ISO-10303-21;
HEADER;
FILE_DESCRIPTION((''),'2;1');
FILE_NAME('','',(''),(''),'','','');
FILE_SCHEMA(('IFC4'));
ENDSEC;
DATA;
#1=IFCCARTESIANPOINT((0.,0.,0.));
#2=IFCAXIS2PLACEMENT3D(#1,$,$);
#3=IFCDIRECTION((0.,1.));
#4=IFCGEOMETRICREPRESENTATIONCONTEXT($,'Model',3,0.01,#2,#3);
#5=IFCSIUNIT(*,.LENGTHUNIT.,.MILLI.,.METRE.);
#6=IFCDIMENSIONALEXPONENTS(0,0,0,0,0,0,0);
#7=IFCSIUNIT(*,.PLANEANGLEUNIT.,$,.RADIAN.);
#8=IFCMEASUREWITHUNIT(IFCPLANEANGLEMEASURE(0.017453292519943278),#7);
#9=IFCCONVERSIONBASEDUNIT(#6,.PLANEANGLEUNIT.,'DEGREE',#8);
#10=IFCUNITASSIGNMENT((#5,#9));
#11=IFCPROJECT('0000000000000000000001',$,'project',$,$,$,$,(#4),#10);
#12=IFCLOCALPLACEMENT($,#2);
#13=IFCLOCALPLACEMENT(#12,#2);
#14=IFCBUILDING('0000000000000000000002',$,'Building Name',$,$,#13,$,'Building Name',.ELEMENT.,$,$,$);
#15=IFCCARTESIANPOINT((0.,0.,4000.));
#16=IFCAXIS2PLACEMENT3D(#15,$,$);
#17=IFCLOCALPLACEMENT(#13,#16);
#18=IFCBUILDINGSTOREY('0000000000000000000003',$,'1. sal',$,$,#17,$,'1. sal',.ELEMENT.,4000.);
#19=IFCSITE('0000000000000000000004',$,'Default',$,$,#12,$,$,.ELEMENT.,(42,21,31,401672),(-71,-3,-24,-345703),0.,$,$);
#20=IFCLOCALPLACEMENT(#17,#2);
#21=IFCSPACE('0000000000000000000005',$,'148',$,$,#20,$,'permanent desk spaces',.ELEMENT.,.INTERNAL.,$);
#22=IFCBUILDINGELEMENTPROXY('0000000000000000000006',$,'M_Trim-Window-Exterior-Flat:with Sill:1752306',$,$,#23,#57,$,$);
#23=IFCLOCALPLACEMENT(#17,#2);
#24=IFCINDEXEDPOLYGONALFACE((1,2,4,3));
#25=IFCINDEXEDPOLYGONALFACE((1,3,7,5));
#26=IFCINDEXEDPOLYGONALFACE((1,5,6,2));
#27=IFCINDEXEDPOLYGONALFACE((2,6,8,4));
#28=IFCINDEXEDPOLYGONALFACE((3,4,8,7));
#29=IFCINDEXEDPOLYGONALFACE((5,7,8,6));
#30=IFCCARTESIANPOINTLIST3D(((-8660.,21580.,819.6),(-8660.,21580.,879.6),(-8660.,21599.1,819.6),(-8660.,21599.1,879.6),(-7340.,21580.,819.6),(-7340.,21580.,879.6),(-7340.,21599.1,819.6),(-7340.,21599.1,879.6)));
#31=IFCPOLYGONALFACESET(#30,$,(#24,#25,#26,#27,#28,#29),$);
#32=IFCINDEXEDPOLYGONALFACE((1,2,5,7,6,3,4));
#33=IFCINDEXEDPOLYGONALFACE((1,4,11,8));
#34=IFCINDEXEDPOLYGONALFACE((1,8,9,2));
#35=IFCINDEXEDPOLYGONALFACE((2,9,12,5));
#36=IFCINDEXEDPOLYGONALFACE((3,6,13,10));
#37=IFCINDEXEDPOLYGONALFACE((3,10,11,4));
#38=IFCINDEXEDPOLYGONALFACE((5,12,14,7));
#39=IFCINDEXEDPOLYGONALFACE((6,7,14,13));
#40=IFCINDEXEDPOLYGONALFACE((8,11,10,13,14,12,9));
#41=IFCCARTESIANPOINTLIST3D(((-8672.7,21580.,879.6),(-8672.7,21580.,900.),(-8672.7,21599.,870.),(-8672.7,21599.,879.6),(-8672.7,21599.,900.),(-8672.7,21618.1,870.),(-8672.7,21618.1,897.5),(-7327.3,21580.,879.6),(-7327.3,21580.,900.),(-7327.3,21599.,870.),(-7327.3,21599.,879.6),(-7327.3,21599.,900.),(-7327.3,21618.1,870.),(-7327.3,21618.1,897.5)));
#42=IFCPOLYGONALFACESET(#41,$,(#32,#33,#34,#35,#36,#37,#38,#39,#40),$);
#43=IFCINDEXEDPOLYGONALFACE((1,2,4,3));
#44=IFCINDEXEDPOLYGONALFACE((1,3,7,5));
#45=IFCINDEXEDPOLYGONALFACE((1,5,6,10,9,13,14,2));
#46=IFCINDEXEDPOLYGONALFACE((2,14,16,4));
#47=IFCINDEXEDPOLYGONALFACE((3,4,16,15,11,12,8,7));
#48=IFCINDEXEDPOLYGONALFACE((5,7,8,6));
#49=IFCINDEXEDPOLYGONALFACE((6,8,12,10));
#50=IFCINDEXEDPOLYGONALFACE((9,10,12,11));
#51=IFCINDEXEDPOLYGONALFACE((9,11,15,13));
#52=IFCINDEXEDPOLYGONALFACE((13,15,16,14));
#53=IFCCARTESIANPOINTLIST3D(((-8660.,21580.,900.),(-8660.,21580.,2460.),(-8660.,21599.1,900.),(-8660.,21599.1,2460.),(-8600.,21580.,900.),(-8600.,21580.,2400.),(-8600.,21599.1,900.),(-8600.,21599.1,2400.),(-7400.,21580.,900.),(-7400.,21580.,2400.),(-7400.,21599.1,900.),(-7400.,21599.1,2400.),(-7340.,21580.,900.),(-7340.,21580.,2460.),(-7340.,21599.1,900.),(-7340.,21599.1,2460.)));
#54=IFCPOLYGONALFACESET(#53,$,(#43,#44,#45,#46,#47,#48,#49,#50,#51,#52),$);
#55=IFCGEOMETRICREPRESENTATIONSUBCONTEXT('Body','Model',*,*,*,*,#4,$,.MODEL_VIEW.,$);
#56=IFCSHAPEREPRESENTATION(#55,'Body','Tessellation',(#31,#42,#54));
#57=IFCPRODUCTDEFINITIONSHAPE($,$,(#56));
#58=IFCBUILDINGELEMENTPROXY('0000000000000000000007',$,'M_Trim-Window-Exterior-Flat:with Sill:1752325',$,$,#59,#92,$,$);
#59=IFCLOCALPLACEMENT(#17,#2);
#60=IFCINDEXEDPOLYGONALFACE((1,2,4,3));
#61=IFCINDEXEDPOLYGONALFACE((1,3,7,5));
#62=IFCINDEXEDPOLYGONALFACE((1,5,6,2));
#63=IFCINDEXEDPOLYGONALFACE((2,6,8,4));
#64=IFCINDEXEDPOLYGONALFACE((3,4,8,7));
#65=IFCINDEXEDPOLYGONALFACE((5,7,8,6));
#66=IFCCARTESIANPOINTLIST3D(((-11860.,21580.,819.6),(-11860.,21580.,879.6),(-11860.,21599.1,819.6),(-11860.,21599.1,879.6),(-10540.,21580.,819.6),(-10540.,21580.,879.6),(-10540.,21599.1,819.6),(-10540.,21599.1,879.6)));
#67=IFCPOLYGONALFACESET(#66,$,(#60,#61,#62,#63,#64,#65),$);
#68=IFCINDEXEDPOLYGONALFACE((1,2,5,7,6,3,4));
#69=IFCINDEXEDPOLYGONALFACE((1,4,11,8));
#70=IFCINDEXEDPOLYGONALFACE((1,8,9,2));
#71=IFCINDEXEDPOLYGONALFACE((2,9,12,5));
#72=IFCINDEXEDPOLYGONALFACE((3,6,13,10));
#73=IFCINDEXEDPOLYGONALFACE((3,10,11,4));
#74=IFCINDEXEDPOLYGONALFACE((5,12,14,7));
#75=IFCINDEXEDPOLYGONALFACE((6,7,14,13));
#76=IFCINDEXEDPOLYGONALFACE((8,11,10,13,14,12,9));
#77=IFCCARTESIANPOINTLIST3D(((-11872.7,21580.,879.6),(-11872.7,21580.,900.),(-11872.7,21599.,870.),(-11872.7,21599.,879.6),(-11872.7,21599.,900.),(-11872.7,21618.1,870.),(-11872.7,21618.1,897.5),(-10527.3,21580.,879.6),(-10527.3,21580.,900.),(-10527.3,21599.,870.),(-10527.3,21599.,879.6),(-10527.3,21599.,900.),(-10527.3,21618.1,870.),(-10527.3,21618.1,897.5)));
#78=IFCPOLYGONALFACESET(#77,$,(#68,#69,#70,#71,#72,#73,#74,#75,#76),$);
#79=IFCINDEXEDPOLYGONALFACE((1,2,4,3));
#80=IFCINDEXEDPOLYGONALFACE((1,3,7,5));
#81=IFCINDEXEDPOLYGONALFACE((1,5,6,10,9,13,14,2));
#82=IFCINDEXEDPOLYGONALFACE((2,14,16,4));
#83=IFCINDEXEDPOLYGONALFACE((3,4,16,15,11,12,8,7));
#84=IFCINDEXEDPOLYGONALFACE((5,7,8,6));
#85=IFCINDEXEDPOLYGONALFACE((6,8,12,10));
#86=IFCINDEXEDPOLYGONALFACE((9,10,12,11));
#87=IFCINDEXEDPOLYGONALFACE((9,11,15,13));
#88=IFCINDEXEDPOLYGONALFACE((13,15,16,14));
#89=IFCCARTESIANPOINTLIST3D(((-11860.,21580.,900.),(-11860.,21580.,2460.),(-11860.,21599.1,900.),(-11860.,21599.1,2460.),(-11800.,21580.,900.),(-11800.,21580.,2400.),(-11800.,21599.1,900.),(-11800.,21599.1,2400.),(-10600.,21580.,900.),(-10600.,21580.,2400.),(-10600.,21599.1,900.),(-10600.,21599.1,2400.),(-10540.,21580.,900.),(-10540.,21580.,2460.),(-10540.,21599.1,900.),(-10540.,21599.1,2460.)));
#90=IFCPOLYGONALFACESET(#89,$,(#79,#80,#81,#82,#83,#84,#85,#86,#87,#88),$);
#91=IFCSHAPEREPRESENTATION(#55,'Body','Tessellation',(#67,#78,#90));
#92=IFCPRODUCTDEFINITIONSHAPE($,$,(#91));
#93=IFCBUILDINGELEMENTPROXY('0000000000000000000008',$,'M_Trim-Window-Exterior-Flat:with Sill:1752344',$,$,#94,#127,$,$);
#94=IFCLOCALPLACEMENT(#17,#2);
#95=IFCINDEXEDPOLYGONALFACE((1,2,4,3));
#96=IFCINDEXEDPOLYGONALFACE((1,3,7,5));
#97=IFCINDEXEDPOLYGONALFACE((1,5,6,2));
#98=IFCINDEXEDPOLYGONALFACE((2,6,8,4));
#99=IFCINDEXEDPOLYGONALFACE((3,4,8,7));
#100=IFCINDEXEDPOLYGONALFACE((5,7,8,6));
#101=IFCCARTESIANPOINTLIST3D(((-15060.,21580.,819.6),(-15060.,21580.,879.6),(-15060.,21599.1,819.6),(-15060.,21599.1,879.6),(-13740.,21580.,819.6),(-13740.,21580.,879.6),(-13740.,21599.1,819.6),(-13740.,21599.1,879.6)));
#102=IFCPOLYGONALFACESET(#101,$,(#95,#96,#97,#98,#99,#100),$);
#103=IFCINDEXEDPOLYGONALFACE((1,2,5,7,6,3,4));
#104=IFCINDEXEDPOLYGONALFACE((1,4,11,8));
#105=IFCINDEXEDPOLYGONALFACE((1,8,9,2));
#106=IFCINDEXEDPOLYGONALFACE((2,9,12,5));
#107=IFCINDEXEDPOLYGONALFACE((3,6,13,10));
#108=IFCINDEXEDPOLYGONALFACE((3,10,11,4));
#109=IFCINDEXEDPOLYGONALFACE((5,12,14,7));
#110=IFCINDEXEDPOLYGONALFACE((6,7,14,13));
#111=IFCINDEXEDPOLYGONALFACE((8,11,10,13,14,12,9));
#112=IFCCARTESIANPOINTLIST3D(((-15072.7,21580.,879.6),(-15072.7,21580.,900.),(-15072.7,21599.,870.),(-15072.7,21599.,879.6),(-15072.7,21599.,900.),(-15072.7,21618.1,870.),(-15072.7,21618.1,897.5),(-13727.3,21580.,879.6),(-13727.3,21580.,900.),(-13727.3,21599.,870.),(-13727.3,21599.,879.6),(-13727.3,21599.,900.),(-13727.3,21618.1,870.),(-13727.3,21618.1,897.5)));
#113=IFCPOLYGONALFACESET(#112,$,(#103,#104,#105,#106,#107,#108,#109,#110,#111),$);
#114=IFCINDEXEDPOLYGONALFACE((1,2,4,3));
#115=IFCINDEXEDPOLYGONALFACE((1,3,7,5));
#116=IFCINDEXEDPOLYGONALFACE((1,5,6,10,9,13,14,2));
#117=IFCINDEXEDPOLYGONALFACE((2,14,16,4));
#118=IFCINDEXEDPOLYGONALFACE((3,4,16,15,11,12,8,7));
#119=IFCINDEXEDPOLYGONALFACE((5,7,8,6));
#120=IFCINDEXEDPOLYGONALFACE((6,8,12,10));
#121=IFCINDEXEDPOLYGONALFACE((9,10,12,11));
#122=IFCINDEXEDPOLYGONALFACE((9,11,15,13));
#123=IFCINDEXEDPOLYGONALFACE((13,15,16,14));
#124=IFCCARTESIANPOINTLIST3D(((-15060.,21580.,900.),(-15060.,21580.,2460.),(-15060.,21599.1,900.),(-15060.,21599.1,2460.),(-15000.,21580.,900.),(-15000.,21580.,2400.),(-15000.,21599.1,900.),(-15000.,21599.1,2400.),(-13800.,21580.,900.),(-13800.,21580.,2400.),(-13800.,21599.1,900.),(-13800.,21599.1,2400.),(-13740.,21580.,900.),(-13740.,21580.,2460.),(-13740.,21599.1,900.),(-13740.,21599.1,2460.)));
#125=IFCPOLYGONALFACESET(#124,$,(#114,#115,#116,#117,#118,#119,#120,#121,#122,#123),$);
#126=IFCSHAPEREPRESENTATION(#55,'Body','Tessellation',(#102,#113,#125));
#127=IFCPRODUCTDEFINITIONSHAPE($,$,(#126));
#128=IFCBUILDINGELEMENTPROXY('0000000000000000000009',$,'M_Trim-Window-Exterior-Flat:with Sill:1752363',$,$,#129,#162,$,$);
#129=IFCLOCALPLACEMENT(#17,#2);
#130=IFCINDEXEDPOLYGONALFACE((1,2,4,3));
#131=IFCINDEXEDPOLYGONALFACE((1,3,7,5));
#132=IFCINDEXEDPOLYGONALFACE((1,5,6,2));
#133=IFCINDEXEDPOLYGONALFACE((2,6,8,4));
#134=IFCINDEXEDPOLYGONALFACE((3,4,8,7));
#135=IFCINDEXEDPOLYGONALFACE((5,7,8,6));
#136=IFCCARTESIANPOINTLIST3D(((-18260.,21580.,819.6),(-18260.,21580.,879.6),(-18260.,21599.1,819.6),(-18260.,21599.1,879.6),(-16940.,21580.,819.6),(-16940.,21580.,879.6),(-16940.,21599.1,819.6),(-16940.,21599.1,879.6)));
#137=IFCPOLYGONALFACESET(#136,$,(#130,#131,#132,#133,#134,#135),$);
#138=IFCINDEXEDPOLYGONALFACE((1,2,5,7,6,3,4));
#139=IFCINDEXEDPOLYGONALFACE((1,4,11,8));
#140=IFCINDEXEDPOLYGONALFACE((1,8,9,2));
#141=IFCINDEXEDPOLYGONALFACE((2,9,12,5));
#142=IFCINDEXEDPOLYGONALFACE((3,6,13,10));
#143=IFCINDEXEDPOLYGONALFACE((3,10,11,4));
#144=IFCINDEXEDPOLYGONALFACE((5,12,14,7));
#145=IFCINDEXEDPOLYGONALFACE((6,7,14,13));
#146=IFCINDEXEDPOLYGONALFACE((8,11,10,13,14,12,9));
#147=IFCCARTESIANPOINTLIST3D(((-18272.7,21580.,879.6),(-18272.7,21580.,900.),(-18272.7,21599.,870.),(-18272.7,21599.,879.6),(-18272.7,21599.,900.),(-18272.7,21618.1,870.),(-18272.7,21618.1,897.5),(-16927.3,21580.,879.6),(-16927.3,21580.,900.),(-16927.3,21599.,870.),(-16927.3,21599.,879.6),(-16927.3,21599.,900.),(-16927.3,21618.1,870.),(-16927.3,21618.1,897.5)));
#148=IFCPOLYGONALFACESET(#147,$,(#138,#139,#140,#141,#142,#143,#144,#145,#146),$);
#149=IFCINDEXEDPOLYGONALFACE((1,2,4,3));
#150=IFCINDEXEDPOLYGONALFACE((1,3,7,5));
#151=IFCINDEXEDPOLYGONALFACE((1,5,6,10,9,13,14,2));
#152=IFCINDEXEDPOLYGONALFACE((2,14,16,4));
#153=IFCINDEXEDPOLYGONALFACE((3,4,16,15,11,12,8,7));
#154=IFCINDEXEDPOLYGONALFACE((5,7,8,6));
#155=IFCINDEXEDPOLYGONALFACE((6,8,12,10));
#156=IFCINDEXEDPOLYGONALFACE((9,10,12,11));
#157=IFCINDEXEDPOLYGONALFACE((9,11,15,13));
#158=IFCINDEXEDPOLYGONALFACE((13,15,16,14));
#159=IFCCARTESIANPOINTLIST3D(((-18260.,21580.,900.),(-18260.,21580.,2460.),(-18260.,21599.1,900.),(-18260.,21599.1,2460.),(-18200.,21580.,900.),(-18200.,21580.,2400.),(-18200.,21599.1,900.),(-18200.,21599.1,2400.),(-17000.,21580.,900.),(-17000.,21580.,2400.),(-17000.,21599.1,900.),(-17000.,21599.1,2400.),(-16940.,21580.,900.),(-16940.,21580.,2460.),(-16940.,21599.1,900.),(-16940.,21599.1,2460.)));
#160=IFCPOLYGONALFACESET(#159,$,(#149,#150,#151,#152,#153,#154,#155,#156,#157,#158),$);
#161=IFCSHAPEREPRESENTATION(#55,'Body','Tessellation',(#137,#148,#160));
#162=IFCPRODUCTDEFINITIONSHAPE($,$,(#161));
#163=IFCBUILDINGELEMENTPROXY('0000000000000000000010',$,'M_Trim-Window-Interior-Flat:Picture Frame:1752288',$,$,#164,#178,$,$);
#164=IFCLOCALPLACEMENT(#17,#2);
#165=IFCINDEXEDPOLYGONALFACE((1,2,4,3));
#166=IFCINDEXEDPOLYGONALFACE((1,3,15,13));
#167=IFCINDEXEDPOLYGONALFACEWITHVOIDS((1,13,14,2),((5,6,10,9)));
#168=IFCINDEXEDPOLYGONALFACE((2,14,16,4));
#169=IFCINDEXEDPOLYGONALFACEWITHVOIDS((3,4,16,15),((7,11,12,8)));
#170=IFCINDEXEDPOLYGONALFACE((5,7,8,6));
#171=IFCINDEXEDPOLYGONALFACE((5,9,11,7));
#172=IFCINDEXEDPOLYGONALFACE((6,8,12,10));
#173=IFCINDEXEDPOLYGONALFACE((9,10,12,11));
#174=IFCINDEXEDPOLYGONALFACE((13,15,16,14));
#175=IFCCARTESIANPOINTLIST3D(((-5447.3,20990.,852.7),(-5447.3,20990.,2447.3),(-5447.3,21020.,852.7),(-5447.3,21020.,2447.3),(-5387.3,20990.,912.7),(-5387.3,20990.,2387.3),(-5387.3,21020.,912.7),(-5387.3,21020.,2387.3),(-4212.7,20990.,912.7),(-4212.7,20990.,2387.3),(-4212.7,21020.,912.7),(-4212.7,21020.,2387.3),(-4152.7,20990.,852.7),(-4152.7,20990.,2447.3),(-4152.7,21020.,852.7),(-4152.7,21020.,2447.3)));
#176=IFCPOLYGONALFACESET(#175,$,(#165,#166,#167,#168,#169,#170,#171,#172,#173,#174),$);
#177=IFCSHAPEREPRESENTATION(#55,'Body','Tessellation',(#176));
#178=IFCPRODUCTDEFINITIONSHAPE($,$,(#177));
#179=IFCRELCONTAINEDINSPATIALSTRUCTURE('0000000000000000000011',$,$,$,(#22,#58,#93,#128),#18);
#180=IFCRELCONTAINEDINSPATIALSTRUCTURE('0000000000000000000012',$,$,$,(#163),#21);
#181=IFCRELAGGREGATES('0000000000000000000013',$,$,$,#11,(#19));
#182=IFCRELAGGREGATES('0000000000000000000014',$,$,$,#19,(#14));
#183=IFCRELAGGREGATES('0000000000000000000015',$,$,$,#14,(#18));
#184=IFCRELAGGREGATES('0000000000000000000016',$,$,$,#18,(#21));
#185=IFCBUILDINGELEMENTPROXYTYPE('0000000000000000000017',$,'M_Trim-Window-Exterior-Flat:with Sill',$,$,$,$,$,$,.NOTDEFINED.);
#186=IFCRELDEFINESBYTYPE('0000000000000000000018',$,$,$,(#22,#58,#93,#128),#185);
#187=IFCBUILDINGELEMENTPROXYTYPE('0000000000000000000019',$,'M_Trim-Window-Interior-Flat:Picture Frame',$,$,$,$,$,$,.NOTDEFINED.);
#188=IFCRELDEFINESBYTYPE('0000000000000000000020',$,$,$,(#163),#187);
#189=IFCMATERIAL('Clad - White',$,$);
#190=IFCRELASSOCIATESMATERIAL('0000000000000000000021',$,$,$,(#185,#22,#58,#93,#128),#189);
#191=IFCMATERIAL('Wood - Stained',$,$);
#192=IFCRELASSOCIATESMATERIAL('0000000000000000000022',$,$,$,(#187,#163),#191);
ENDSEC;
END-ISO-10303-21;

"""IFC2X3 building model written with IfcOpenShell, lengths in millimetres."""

from ifc_helpers import new_model, entity, si_unit, converted_unit, direction, frame, frame_2d, origin, place, context, subcontext, project, spatial, polyline, rectangle, outline, extrude, source, transform, mapped, material, type_object, type_shapes, element, save


model = new_model("IFC2X3")

# Units and contexts
model_context = context("Model", 3, precision=0.01, world=origin(), true_north=direction((0.0, 1.0)))
body_context = subcontext(model_context, "Body", "Model", "MODEL_VIEW")
ifc_project = project(units=[si_unit("LENGTHUNIT", "METRE", prefix="MILLI"), converted_unit("PLANEANGLEUNIT", "DEGREE", entity("IfcPlaneAngleMeasure", 0.017453292519943278), si_unit("PLANEANGLEUNIT", "RADIAN"), dimensions=[0, 0, 0, 0, 0, 0, 0])], contexts=[model_context])

# Site, building, storey
site_placement = place(None, origin())
site = spatial("IfcSite", under=ifc_project, at=site_placement, Name="Default", CompositionType="ELEMENT", RefLatitude=(42, 21, 31, 401672), RefLongitude=(-71, -3, -24, -345703), RefElevation=0.0)
building_placement = place(site_placement, origin())
building = spatial("IfcBuilding", under=site, at=building_placement, Name="Building Name", LongName="Building Name", CompositionType="ELEMENT")
storey_placement = place(building_placement, frame((0.0, 0.0, 4000.0)))
storey = spatial("IfcBuildingStorey", under=building, at=storey_placement, Name="1. sal", LongName="1. sal", CompositionType="ELEMENT", Elevation=4000.0)

# Building element proxies
ifc_material_1 = material(Name="Clad - White")
ifc_material_2 = material(Name="Wood - Stained")
building_element_proxy_type_1 = type_object("IfcBuildingElementProxyType", Name="M_Trim-Window-Exterior-Flat:with Sill", PredefinedType="NOTDEFINED", material=ifc_material_1)
shared_shape_1 = source(origin(), body_context, "Body", "SweptSolid", [
    extrude(rectangle(XDim=1320.0, YDim=60.0, at=frame_2d((0.0, 0.0), x_axis=(1.0, 0.0))), frame((0.0, -1550.4, 0.0), z_axis=(0.0, 0.0, 1.0), x_axis=(-1.0, 0.0, 0.0)), (0.0, 0.0, 1.0), 19.0),
    extrude(outline(polyline([(-19.0, -15.2), (0.0, -15.2), (0.0, -5.7), (19.0, -5.7), (19.0, 14.8), (0.0, 14.8), (-19.0, 12.3), (-19.0, -15.2)])), frame((-672.7, -1514.8, 19.0), z_axis=(1.0, 0.0, 0.0), x_axis=(0.0, 0.0, -1.0)), (0.0, 0.0, 1.0), 1345.4),
    extrude(outline(polyline([(-795.0, -660.0), (765.0, -660.0), (765.0, -600.0), (-735.0, -600.0), (-735.0, 600.0), (765.0, 600.0), (765.0, 660.0), (-795.0, 660.0), (-795.0, -660.0)])), frame((0.0, -735.0, 0.0), z_axis=(0.0, 0.0, 1.0), x_axis=(0.0, -1.0, 0.0)), (0.0, 0.0, 1.0), 19.0),
])
type_shapes(building_element_proxy_type_1, [shared_shape_1])
for number, where, z_axis, x_axis, name in (
    (1, (-8000.0, 21580.0, 2400.0), (0.0, 1.0, 0.0), (-1.0, 0.0, 0.0), "M_Trim-Window-Exterior-Flat:with Sill:1752306"),
    (2, (-11200.0, 21580.0, 2400.0), (0.0, 1.0, 0.0), (-1.0, 0.0, 0.0), "M_Trim-Window-Exterior-Flat:with Sill:1752325"),
    (3, (-14400.0, 21580.0, 2400.0), (0.0, 1.0, 0.0), (-1.0, 0.0, 0.0), "M_Trim-Window-Exterior-Flat:with Sill:1752344"),
    (4, (-17600.0, 21580.0, 2400.0), (0.0, 1.0, 0.0), (-1.0, 0.0, 0.0), "M_Trim-Window-Exterior-Flat:with Sill:1752363"),
):
    element("IfcBuildingElementProxy", number, at=place(storey_placement, frame(where, z_axis=z_axis, x_axis=x_axis)), inside=storey, type_object=building_element_proxy_type_1, material=ifc_material_1, Name=name, context=body_context, shape_type="MappedRepresentation", body=[
        mapped(shared_shape_1, transform((0.0, 0.0, 0.0), scale=1.0)),
    ])

# Shared definitions
space_placement = place(storey_placement, origin())
space = spatial("IfcSpace", under=storey, at=space_placement, Name="148", LongName="permanent desk spaces", CompositionType="ELEMENT", InteriorOrExteriorSpace="INTERNAL")

# Building element proxy
building_element_proxy_type_2 = type_object("IfcBuildingElementProxyType", Name="M_Trim-Window-Interior-Flat:Picture Frame", PredefinedType="NOTDEFINED", material=ifc_material_2)
shared_shape_2 = source(origin(), body_context, "Body", "SweptSolid", [
    extrude(outline(polyline([(-647.3, -797.3), (647.3, -797.3), (647.3, 797.3), (-647.3, 797.3), (-647.3, -797.3)]), holes=[polyline([(-587.3, -737.3), (-587.3, 737.3), (587.3, 737.3), (587.3, -737.3), (-587.3, -737.3)])]), frame((0.0, -750.0, 0.0), z_axis=(0.0, 0.0, 1.0), x_axis=(-1.0, 0.0, 0.0)), (0.0, 0.0, 1.0), 30.0),
])
type_shapes(building_element_proxy_type_2, [shared_shape_2])
proxy_placement = place(space_placement, frame((-4800.0, 21020.0, 2400.0), z_axis=(0.0, -1.0, 0.0), x_axis=(1.0, 0.0, 0.0)))
element("IfcBuildingElementProxy", 5, at=proxy_placement, inside=space, type_object=building_element_proxy_type_2, material=ifc_material_2, Name="M_Trim-Window-Interior-Flat:Picture Frame:1752288", context=body_context, shape_type="MappedRepresentation", body=[
    mapped(shared_shape_2, transform((0.0, 0.0, 0.0), scale=1.0)),
])

save(model, "model.ifc")
